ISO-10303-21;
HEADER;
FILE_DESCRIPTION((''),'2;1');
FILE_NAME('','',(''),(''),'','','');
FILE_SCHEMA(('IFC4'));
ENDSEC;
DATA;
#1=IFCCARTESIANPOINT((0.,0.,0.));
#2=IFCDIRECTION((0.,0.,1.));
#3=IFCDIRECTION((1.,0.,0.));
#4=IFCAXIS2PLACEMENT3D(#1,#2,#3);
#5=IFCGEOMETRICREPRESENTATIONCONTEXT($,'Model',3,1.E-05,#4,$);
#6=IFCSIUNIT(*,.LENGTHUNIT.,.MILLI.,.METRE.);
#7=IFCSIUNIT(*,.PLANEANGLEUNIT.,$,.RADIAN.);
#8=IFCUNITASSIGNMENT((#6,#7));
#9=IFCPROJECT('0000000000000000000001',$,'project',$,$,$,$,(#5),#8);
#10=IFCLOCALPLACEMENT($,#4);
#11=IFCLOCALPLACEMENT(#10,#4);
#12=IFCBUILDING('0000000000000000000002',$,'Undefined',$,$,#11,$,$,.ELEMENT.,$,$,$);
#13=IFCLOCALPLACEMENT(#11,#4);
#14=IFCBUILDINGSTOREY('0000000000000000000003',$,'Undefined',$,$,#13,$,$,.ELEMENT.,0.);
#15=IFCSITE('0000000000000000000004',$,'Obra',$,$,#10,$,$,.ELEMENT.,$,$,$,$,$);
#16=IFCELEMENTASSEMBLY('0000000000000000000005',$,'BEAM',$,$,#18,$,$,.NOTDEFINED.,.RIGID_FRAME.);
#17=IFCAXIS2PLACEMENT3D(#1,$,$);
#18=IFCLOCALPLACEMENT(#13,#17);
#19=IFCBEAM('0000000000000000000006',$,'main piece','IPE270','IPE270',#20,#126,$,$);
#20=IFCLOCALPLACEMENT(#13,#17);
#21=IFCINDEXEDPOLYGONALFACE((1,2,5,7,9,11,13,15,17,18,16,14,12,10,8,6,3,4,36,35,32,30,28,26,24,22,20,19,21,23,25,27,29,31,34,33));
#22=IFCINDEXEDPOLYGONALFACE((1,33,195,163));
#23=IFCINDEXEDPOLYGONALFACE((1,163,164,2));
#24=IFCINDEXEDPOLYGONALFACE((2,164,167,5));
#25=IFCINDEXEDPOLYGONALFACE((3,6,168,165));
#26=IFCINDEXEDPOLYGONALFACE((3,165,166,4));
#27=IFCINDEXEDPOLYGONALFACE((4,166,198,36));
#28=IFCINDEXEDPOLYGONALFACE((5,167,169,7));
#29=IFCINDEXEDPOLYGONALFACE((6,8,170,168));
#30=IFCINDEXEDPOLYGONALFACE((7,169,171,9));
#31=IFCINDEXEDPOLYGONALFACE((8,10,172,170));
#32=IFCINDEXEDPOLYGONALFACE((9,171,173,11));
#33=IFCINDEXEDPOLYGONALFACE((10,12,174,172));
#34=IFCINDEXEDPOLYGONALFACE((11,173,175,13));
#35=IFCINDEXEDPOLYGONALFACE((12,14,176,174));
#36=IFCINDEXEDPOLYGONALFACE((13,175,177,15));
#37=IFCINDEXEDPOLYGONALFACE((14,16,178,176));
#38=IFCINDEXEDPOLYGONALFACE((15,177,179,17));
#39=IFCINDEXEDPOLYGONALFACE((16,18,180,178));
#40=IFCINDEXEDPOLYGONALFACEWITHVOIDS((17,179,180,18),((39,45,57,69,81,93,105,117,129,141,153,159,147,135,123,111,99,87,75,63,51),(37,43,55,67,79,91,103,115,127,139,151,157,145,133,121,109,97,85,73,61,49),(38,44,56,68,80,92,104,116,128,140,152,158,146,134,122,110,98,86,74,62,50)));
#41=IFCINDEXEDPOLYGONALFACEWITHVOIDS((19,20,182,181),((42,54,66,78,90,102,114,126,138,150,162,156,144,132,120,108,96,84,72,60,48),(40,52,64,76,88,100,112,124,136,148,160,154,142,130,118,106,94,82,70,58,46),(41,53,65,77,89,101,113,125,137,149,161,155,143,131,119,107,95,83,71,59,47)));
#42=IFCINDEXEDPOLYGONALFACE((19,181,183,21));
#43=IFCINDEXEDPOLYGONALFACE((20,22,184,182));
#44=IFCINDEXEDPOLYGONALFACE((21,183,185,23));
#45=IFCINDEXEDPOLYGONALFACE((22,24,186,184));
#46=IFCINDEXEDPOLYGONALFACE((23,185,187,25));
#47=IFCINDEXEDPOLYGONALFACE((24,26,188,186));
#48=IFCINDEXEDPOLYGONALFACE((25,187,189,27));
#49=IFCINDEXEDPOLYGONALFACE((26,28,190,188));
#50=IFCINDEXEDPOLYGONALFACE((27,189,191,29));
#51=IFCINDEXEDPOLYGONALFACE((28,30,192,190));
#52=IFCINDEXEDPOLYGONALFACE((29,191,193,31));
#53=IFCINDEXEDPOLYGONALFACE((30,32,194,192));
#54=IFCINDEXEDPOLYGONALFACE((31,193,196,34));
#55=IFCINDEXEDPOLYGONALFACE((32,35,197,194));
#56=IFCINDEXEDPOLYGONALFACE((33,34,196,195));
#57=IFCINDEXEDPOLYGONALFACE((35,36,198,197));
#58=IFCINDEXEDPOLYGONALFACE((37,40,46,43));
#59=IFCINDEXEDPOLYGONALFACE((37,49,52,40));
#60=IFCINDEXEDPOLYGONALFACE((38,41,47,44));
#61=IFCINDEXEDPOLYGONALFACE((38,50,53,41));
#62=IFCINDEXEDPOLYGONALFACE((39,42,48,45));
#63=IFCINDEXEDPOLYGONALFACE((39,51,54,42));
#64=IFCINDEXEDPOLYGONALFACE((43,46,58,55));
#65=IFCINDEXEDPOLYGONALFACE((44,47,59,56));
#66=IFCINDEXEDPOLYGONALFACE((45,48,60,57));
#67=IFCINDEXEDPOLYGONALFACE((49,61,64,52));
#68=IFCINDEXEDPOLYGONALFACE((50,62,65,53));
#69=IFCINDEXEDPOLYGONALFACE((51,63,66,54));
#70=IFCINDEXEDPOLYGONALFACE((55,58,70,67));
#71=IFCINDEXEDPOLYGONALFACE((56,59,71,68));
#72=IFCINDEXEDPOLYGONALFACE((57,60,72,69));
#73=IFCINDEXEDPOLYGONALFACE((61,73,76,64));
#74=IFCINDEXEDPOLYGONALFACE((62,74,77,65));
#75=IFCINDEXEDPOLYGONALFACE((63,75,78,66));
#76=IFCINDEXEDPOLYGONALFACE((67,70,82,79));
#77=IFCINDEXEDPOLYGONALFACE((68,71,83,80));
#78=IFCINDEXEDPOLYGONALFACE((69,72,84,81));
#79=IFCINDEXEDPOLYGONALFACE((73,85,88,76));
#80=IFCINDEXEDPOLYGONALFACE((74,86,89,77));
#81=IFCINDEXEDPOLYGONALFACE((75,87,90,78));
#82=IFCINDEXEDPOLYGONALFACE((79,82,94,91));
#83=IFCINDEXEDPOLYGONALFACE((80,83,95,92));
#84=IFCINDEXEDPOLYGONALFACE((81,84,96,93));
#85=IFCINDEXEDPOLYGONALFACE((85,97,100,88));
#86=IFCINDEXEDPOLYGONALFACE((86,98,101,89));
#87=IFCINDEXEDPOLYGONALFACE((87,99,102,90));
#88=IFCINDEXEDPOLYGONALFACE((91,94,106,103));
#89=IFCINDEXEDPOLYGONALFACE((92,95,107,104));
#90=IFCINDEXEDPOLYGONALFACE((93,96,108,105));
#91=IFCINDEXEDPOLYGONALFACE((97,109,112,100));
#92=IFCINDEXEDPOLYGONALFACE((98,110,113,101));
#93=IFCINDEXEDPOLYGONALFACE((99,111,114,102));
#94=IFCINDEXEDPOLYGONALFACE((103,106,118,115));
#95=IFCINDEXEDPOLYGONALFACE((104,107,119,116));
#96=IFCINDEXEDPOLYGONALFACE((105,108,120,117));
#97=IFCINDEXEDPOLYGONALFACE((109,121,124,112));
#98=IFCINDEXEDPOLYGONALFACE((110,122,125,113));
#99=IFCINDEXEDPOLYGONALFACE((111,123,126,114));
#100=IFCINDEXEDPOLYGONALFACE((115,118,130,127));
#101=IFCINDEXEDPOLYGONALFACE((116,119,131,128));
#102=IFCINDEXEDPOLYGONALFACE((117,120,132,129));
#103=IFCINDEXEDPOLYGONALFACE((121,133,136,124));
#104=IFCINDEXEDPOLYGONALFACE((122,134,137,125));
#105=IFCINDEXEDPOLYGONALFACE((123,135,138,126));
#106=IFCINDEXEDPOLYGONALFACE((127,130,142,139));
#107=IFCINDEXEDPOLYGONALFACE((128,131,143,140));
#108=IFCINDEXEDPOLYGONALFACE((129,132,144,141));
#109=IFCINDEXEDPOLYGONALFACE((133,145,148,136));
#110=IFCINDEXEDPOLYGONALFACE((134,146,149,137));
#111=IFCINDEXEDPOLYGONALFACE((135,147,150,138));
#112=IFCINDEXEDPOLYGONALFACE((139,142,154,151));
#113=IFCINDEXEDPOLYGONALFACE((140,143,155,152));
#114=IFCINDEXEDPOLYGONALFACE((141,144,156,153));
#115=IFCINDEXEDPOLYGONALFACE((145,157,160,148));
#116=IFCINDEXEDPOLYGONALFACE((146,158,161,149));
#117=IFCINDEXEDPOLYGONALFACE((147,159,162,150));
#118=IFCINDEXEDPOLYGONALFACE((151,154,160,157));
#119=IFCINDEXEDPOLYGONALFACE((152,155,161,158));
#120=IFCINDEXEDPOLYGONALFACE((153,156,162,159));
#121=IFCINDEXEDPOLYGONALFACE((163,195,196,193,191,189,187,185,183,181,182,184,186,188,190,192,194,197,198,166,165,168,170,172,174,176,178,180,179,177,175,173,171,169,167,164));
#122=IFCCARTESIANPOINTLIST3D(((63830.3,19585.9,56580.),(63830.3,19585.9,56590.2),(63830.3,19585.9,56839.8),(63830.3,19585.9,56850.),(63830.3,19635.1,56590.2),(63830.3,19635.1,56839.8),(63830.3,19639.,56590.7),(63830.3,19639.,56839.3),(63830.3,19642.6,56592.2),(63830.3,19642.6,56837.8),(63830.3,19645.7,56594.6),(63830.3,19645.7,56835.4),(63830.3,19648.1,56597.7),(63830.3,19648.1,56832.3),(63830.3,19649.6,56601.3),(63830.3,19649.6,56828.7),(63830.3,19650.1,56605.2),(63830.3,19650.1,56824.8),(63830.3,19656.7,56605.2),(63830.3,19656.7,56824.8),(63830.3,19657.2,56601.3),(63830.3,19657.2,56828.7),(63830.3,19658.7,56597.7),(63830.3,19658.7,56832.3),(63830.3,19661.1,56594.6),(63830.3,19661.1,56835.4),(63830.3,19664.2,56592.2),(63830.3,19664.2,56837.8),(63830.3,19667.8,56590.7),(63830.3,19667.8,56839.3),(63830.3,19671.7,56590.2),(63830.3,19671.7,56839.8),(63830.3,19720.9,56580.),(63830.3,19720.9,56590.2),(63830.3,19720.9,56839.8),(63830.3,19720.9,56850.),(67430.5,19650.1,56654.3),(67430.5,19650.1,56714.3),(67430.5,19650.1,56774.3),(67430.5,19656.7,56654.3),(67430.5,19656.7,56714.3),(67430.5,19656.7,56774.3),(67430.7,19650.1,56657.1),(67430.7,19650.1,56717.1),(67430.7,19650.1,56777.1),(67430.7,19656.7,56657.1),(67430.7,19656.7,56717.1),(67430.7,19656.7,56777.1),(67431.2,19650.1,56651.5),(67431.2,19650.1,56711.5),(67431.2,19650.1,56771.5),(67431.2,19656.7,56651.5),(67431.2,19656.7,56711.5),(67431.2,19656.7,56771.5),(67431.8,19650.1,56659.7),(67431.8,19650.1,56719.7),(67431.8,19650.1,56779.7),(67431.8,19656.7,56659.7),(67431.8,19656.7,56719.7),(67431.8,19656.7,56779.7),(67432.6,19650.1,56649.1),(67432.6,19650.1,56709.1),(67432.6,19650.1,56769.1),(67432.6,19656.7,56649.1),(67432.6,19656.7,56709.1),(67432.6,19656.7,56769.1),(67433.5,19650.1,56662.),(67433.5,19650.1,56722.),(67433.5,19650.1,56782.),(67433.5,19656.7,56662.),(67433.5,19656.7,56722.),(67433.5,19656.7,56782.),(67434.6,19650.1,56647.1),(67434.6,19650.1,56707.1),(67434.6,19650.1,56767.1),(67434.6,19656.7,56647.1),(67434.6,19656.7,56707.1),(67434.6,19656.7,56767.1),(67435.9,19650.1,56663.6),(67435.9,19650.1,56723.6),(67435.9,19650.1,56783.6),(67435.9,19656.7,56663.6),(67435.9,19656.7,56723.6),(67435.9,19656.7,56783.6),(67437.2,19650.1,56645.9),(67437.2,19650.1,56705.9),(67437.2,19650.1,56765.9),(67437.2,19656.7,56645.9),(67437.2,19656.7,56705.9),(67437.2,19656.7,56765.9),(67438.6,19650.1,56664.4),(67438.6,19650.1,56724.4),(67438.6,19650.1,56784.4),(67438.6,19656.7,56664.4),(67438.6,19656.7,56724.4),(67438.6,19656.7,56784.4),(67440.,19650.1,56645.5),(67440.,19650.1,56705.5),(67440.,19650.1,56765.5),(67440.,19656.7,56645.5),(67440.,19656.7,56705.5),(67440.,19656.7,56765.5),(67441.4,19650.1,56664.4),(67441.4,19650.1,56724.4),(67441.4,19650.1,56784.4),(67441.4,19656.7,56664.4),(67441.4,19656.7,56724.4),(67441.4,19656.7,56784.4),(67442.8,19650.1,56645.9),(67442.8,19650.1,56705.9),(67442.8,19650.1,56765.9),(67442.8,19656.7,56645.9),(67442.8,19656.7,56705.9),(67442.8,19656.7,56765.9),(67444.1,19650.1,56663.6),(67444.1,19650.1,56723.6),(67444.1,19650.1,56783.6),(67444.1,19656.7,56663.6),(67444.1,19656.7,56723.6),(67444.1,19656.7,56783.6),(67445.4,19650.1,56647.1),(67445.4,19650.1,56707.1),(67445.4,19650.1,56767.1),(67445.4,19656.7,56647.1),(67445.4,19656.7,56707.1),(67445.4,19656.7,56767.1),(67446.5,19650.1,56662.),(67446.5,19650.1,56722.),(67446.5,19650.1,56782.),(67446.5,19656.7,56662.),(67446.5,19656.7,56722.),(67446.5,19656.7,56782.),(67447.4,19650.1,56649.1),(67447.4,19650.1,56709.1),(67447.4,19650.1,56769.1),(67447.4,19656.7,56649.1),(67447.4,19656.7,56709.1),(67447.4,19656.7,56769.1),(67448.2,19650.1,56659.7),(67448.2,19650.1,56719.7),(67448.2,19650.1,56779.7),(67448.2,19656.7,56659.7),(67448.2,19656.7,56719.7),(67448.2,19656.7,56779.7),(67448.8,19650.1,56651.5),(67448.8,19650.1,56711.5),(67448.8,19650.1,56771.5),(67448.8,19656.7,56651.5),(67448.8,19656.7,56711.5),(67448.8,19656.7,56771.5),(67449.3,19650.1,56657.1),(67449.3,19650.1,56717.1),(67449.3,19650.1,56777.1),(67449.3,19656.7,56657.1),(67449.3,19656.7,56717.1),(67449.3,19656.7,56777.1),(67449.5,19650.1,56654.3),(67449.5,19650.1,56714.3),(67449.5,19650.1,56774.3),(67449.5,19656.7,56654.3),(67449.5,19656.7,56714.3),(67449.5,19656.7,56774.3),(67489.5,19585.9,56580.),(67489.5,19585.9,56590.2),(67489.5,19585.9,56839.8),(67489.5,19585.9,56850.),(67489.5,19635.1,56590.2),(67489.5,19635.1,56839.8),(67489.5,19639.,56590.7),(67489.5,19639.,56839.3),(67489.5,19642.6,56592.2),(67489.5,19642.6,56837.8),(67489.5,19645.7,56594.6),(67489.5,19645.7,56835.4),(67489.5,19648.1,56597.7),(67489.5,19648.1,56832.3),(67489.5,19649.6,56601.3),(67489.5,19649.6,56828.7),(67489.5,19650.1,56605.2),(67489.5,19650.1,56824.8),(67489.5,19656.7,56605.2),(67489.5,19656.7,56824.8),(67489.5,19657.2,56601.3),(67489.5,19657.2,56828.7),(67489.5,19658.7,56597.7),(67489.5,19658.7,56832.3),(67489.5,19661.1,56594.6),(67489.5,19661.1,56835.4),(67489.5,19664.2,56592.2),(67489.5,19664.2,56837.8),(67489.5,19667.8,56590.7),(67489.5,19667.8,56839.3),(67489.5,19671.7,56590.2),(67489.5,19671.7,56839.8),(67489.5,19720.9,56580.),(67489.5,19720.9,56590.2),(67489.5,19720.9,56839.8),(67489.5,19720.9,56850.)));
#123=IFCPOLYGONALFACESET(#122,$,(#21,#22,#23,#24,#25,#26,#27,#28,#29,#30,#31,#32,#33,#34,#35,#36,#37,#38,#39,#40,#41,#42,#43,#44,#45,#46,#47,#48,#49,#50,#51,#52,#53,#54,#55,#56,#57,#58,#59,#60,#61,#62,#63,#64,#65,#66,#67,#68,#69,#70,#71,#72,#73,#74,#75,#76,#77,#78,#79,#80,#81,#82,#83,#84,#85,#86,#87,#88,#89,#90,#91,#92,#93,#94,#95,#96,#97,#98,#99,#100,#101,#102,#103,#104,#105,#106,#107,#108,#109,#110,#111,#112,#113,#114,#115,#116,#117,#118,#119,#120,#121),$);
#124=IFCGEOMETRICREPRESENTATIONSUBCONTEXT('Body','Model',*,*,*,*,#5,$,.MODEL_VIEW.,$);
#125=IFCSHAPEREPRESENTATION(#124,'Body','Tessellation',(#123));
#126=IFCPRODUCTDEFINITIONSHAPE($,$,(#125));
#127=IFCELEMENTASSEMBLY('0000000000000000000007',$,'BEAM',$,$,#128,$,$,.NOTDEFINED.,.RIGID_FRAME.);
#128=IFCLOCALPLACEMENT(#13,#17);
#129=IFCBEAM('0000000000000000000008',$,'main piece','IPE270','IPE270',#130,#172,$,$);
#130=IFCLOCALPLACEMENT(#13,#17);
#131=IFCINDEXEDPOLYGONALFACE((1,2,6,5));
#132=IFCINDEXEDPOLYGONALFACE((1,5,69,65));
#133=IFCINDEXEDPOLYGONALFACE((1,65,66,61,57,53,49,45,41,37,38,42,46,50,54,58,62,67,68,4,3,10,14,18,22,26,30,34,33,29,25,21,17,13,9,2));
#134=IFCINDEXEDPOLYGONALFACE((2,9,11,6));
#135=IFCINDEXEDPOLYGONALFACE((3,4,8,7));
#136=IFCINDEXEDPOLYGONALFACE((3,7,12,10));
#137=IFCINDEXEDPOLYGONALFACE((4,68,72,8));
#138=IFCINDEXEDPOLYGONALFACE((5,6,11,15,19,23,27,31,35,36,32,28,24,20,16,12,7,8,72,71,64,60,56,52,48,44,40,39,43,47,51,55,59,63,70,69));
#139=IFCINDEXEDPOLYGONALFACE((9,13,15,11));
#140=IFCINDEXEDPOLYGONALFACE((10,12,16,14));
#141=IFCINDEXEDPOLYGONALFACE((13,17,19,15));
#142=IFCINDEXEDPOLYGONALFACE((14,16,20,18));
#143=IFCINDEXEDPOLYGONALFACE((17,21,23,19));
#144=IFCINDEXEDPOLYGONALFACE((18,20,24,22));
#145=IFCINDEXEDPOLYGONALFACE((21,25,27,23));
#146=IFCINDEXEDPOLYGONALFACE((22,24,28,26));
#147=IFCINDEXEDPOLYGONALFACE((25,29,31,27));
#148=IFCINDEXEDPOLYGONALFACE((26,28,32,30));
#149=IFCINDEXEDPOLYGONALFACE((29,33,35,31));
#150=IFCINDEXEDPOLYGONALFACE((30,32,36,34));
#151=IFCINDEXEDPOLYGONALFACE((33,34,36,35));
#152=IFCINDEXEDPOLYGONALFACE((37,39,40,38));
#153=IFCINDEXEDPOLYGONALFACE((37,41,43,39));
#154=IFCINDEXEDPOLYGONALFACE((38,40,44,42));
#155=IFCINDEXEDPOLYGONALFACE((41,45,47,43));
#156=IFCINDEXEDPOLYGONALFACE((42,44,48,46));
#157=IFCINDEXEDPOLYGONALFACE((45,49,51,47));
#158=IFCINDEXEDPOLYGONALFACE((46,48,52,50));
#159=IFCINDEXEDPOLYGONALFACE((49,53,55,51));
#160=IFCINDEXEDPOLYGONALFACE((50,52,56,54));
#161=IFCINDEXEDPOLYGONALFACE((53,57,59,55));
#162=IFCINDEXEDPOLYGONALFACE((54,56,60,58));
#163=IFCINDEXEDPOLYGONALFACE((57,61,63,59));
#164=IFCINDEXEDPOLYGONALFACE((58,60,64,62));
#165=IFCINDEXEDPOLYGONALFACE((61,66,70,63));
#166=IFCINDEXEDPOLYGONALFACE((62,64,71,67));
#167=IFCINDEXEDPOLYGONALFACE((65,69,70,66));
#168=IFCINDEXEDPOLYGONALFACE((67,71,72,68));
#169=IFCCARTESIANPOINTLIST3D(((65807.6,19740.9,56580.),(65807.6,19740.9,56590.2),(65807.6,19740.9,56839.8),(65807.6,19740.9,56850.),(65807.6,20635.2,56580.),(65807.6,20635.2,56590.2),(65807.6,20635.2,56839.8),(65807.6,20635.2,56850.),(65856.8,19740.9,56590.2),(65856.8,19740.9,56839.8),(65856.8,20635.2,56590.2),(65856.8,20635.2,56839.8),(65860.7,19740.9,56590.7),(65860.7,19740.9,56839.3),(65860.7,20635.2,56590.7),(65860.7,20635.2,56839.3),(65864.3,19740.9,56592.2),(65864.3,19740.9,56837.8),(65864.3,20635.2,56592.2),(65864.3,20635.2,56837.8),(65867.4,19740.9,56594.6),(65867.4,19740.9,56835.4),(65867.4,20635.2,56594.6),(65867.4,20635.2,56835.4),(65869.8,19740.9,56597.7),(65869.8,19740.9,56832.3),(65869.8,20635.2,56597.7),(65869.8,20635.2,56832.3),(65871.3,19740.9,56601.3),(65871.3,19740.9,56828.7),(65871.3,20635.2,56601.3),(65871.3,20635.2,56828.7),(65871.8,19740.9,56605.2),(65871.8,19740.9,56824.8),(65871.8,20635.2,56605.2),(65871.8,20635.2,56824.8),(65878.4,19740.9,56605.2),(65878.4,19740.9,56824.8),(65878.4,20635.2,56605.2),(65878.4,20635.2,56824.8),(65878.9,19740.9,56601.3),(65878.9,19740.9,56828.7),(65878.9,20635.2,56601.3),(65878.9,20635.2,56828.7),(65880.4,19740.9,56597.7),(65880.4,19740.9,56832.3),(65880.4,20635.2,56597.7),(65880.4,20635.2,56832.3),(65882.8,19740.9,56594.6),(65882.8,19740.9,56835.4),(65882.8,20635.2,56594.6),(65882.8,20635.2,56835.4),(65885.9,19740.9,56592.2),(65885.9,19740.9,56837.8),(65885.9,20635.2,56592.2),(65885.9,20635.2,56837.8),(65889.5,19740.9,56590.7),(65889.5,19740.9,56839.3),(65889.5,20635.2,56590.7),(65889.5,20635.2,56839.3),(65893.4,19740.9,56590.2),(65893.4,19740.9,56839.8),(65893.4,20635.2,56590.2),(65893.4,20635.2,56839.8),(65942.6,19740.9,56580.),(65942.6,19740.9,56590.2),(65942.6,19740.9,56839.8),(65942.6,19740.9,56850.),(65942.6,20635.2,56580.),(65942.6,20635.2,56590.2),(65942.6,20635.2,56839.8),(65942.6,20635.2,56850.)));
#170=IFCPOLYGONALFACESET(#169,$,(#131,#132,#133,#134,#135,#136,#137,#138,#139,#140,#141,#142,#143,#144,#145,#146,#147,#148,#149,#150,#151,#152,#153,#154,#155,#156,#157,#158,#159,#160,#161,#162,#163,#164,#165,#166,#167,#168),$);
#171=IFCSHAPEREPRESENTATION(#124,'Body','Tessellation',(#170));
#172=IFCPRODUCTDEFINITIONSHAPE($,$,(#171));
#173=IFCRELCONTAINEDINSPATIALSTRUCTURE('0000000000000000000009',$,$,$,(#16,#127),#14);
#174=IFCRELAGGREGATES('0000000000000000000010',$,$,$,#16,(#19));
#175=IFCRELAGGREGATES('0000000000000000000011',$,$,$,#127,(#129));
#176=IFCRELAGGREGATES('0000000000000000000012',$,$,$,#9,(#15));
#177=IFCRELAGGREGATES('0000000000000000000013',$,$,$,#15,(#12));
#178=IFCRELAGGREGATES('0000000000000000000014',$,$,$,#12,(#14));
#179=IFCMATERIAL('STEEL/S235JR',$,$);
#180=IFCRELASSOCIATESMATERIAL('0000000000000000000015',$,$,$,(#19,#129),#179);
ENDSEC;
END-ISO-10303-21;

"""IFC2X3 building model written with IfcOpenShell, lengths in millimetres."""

from ifc_helpers import new_model, si_unit, frame, origin_with_axes, origin_2d_with_axis, place, context, subcontext, project, spatial, circle, i_section, extrude, clip, halfspace, source, transform, mapped, material, element, aggregate, save


model = new_model("IFC2X3")

# Units and contexts
model_context = context("Model", 3, precision=1e-05, world=origin_with_axes())
body_context = subcontext(model_context, "Body", "Model", "MODEL_VIEW")
ifc_project = project(units=[si_unit("LENGTHUNIT", "METRE", prefix="MILLI"), si_unit("PLANEANGLEUNIT", "RADIAN")], contexts=[model_context])

# Site, building, storey
site_placement = place(None, origin_with_axes())
site = spatial("IfcSite", under=ifc_project, at=site_placement, Name="Obra", CompositionType="ELEMENT")
building_placement = place(site_placement, origin_with_axes())
building = spatial("IfcBuilding", under=site, at=building_placement, Name="Undefined", CompositionType="ELEMENT")
storey_placement = place(building_placement, origin_with_axes())
storey = spatial("IfcBuildingStorey", under=building, at=storey_placement, Name="Undefined", CompositionType="ELEMENT", Elevation=0.0)

# Shared definitions
ifc_material_1 = material(Name="STEEL/S235JR")

# Element assembly, beam, opening
assembly_1_placement = place(storey_placement, origin_with_axes())
assembly_1 = element("IfcElementAssembly", 1, at=assembly_1_placement, inside=storey, Name="BEAM", AssemblyPlace="NOTDEFINED", PredefinedType="RIGID_FRAME")
beam_1_placement = place(assembly_1_placement, frame((63830.3, 19653.4, 56715.0), z_axis=(0.0, 0.0, 1.0), x_axis=(1.0, 0.000002, 0.0)))
beam_1 = element("IfcBeam", 2, at=beam_1_placement, material=ifc_material_1, Name="main piece", Description="IPE270", ObjectType="IPE270", context=body_context, shape_type="Clipping", body=[
    clip(extrude(i_section(OverallWidth=135.0, OverallDepth=270.0, WebThickness=6.6, FlangeThickness=10.2, FilletRadius=15.0, at=origin_2d_with_axis()), frame((3889.9, 0.0, 0.0), z_axis=(-1.0, 0.0, 0.0), x_axis=(0.0, -1.0, 0.0)), (0.0, 0.0, 1.0), 3889.9), halfspace(frame((3659.2, -60.0, -120.0), z_axis=(1.0, 0.000017, 0.0), x_axis=(0.0, 0.0, 1.0)), False)),
])
shared_shape_1 = source(origin_with_axes(), body_context, "Body", "SweptSolid", [
    extrude(circle(Radius=9.5, at=origin_2d_with_axis()), frame((0.0, -3.4, 0.0), z_axis=(0.0, 1.0, 0.0), x_axis=(1.0, 0.0, 0.0)), (0.0, 0.0, 1.0), 6.8),
])
opening_1_placement = place(assembly_1_placement, frame((67490.0, 19653.4, 56835.0), z_axis=(-1.0, 0.0, 0.0), x_axis=(0.0, 0.0, -1.0)))
element("IfcOpeningElement", 3, at=opening_1_placement, cuts=beam_1, ObjectType="Opening", context=body_context, shape_type="MappedRepresentation", body=[
    mapped(shared_shape_1, transform((60.0, 0.0, 50.0))),
    mapped(shared_shape_1, transform((120.0, 0.0, 50.0))),
    mapped(shared_shape_1, transform((180.0, 0.0, 50.0))),
])
aggregate(assembly_1, [beam_1])

# Element assembly, beam
assembly_2_placement = place(storey_placement, origin_with_axes())
assembly_2 = element("IfcElementAssembly", 4, at=assembly_2_placement, inside=storey, Name="BEAM", AssemblyPlace="NOTDEFINED", PredefinedType="RIGID_FRAME")
beam_2_placement = place(assembly_2_placement, frame((65875.1, 20635.2, 56715.0), z_axis=(0.0, 0.0, 1.0), x_axis=(0.0, -1.0, 0.0)))
beam_2 = element("IfcBeam", 5, at=beam_2_placement, material=ifc_material_1, Name="main piece", Description="IPE270", ObjectType="IPE270", context=body_context, shape_type="SweptSolid", body=[
    extrude(i_section(OverallWidth=135.0, OverallDepth=270.0, WebThickness=6.6, FlangeThickness=10.2, FilletRadius=15.0, at=origin_2d_with_axis()), frame((894.3, 0.0, 0.0), z_axis=(-1.0, 0.0, 0.0), x_axis=(0.0, -1.0, 0.0)), (0.0, 0.0, 1.0), 894.3),
])
aggregate(assembly_2, [beam_2])

save(model, "model.ifc")
